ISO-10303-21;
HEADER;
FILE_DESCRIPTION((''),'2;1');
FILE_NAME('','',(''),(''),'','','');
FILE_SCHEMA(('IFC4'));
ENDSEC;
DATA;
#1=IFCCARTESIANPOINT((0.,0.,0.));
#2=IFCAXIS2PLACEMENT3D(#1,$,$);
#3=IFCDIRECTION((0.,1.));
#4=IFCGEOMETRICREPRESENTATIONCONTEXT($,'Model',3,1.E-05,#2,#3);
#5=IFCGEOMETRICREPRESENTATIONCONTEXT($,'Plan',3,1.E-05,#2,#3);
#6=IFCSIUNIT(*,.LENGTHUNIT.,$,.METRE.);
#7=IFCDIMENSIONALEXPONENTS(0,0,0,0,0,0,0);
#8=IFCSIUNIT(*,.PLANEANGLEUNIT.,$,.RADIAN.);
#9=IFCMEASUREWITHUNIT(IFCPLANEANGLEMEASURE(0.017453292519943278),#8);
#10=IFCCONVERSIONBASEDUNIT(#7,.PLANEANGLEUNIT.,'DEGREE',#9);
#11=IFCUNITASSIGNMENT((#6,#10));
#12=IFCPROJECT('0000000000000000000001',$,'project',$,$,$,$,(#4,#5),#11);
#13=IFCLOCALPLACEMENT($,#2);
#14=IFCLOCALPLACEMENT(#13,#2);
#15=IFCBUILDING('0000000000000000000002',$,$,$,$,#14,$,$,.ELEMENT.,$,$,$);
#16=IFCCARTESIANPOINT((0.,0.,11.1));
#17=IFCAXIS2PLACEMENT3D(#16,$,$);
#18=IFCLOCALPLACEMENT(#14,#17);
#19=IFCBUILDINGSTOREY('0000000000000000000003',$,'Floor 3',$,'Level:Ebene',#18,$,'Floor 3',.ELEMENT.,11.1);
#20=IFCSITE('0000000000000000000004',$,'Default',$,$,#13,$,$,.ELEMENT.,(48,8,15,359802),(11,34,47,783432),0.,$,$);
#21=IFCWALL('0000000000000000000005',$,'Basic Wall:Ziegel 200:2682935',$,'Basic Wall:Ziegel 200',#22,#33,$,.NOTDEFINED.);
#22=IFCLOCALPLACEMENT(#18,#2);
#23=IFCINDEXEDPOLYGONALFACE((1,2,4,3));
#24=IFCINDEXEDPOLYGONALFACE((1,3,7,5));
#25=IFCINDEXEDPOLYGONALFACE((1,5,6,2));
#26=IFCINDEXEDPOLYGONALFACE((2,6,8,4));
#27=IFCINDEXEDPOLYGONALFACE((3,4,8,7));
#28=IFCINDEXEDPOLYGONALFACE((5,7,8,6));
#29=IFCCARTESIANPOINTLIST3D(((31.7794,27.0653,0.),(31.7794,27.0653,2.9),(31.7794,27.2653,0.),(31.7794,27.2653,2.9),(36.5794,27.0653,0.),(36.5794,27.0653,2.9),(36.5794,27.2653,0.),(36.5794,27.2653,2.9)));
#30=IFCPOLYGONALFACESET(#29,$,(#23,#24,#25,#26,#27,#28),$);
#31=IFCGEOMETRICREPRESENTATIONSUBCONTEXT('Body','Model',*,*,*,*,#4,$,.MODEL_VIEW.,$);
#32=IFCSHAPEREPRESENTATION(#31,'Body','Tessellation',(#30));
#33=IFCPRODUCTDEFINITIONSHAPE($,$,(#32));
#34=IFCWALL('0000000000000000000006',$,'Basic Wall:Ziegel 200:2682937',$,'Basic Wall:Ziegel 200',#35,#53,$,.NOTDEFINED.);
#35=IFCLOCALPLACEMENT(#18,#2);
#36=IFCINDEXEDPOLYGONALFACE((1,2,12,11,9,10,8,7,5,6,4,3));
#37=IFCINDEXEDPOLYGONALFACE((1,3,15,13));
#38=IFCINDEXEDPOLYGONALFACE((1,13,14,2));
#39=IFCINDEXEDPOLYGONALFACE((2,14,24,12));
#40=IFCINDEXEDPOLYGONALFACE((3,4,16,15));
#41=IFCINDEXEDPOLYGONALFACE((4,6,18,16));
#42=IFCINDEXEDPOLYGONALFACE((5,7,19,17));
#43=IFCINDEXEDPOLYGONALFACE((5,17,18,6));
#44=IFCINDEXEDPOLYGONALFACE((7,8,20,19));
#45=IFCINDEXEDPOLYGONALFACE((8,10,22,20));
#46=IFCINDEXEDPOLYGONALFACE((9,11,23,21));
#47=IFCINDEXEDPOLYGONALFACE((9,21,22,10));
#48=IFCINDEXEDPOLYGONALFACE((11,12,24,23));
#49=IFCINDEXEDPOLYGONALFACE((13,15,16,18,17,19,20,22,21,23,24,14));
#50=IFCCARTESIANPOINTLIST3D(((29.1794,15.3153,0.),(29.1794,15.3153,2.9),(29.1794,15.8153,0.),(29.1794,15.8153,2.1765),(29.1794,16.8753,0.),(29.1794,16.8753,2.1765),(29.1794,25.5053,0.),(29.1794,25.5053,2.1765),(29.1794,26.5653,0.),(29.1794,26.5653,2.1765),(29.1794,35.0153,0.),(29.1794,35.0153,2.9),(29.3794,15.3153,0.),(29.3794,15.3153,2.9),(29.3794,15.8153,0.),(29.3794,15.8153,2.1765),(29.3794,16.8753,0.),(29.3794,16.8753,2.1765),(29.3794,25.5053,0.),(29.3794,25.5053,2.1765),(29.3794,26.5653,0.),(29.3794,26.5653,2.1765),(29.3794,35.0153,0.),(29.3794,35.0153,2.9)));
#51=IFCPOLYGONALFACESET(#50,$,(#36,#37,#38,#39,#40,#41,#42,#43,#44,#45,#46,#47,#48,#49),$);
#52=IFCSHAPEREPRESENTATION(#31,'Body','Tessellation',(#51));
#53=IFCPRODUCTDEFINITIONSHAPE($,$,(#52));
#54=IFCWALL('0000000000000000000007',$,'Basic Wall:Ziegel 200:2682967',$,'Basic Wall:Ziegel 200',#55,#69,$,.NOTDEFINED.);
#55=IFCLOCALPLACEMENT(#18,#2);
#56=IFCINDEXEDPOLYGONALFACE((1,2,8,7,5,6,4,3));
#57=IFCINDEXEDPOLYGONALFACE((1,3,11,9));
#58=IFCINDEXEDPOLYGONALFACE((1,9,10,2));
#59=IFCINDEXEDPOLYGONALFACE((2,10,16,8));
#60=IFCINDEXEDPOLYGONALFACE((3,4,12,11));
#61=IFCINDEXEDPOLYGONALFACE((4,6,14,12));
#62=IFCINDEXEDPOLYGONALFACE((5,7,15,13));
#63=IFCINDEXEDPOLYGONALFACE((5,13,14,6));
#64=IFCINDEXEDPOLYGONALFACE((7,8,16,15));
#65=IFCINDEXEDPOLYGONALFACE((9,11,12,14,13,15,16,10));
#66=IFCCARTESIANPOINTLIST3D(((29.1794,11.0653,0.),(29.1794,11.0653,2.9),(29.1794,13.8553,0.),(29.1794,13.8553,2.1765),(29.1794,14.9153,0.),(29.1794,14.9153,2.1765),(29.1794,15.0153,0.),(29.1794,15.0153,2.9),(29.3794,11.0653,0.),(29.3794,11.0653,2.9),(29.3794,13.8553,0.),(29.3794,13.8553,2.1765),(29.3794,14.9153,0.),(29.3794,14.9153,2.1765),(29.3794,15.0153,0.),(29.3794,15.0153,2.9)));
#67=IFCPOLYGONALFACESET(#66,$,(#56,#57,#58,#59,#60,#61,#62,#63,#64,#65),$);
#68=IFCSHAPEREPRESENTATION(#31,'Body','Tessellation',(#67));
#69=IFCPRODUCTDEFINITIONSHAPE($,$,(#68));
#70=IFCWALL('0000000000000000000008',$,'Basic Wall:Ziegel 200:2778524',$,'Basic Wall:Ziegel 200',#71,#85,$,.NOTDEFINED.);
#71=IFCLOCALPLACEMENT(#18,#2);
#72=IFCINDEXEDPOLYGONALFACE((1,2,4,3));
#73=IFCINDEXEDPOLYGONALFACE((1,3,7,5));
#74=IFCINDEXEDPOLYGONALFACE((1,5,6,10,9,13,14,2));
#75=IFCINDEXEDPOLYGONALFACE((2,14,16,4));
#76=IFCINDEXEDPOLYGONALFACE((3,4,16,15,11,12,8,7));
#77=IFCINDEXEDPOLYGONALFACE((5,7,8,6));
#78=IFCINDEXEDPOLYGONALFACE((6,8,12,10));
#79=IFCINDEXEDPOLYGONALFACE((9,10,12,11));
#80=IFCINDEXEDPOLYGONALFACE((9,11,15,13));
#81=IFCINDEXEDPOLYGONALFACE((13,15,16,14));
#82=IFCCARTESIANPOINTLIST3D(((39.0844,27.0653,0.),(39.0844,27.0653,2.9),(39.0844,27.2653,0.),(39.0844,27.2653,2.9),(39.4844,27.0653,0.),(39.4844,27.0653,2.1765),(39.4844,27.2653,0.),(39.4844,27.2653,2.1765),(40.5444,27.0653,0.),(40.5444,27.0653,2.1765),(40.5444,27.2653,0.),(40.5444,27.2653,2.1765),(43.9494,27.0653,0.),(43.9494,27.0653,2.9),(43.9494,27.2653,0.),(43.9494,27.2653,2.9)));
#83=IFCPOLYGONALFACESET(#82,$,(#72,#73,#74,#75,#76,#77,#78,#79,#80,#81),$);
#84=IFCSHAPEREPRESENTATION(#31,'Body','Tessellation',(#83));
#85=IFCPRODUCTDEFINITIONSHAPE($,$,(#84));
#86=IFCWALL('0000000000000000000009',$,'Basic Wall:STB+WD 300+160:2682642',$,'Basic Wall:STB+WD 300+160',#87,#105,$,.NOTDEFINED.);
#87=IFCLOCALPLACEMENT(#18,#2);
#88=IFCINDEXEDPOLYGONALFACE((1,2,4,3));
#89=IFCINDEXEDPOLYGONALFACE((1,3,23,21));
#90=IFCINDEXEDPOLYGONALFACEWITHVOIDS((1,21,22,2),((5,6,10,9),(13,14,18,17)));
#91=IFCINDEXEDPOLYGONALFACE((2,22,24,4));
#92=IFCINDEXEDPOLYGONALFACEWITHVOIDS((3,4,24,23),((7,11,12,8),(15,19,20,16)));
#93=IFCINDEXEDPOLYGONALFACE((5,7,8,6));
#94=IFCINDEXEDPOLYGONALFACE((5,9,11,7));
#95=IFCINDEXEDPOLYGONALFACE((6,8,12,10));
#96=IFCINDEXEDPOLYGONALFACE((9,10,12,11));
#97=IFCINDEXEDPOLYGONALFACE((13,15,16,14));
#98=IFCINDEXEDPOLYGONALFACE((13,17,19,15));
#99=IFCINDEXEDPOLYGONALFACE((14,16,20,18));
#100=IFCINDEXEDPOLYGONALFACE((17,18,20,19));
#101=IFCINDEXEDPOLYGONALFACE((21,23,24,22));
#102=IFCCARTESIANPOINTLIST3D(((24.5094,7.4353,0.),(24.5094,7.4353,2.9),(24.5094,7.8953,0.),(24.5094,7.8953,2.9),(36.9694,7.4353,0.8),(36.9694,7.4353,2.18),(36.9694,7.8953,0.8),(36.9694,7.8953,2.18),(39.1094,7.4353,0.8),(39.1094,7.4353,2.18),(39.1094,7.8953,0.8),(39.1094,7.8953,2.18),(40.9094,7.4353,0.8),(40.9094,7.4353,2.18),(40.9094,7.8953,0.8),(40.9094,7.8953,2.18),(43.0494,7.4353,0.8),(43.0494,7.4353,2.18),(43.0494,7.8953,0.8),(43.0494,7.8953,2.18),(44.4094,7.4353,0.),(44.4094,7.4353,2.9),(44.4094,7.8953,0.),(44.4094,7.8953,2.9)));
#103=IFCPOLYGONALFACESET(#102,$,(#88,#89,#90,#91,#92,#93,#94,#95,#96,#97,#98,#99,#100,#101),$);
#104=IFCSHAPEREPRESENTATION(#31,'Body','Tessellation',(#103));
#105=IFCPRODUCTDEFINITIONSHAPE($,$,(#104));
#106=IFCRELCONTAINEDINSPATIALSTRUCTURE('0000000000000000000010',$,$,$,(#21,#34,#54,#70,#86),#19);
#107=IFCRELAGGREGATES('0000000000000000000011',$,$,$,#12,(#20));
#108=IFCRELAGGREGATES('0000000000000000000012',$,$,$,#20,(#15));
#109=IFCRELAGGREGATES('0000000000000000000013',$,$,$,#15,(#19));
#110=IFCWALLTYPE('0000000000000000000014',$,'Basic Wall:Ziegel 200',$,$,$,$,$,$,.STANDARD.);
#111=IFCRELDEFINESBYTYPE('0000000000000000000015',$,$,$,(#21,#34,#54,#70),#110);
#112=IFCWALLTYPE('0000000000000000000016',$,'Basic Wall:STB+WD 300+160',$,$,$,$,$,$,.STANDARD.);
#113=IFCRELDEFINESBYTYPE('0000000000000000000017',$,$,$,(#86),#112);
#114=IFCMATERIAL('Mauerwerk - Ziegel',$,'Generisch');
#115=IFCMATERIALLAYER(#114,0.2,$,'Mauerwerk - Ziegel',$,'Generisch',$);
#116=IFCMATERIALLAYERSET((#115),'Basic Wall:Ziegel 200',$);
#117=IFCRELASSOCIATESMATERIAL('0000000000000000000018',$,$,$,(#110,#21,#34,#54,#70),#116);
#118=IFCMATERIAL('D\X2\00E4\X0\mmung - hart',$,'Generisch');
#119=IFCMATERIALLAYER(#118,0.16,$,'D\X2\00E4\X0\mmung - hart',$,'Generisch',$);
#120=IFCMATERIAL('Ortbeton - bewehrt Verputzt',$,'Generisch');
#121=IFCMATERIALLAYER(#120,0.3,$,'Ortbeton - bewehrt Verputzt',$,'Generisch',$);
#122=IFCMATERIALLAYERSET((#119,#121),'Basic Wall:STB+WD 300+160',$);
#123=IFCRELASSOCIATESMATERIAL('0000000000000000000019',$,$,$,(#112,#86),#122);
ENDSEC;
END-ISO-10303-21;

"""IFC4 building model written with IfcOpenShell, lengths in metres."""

from ifc_helpers import new_model, entity, si_unit, converted_unit, direction, frame, frame_2d, origin, place, context, subcontext, project, spatial, rectangle, extrude, material, layer, layer_set, layer_usage, type_object, element, save


model = new_model("IFC4")

# Units and contexts
model_context = context("Model", 3, precision=1e-05, world=origin(), true_north=direction((0.0, 1.0)))
plan_context = context("Plan", 3, precision=1e-05, world=origin(), true_north=direction((0.0, 1.0)))
body_context = subcontext(model_context, "Body", "Model", "MODEL_VIEW")
ifc_project = project(units=[si_unit("LENGTHUNIT", "METRE"), converted_unit("PLANEANGLEUNIT", "DEGREE", entity("IfcPlaneAngleMeasure", 0.017453292519943278), si_unit("PLANEANGLEUNIT", "RADIAN"), dimensions=[0, 0, 0, 0, 0, 0, 0])], contexts=[model_context, plan_context])

# Site, building, storey
site_placement = place(None, origin())
site = spatial("IfcSite", under=ifc_project, at=site_placement, Name="Default", CompositionType="ELEMENT", RefLatitude=(48, 8, 15, 359802), RefLongitude=(11, 34, 47, 783432), RefElevation=0.0)
building_placement = place(site_placement, origin())
building = spatial("IfcBuilding", under=site, at=building_placement, CompositionType="ELEMENT")
storey_placement = place(building_placement, frame((0.0, 0.0, 11.1)))
storey = spatial("IfcBuildingStorey", under=building, at=storey_placement, Name="Floor 3", ObjectType="Level:Ebene", LongName="Floor 3", CompositionType="ELEMENT", Elevation=11.1)

# Shared definitions
ifc_material_1 = material(Name="Ortbeton - bewehrt Verputzt", Category="Generisch")

# Shared definitions
ifc_material_2 = material(Name="Mauerwerk - Ziegel", Category="Generisch")
ifc_layer_1 = layer(ifc_material_2, 0.2, Name="Mauerwerk - Ziegel", Category="Generisch")
ifc_layer_set_1 = layer_set([ifc_layer_1], Name="Basic Wall:Ziegel 200")
ifc_layer_usage_1 = layer_usage(ifc_layer_set_1, "AXIS2", "NEGATIVE", 0.1)
wall_type_1 = type_object("IfcWallType", Name="Basic Wall:Ziegel 200", PredefinedType="STANDARD", material=ifc_layer_set_1)

# Wall
wall_1_placement = place(storey_placement, frame((31.7794, 27.1653, 0.0)))
element("IfcWall", 1, at=wall_1_placement, inside=storey, type_object=wall_type_1, material=ifc_layer_usage_1, Name="Basic Wall:Ziegel 200:2682935", ObjectType="Basic Wall:Ziegel 200", PredefinedType="NOTDEFINED", context=body_context, shape_type="SweptSolid", body=[
    extrude(rectangle(XDim=4.8, YDim=0.2, at=frame_2d((2.4, 0.0), x_axis=(-1.0, 0.0))), origin(), (0.0, 0.0, 1.0), 2.9),
])

# Wall, openings
wall_2_placement = place(storey_placement, frame((29.2794, 15.3153, 0.0), z_axis=(0.0, 0.0, 1.0), x_axis=(0.0, 1.0, 0.0)))
wall_2 = element("IfcWall", 2, at=wall_2_placement, inside=storey, type_object=wall_type_1, material=ifc_layer_usage_1, Name="Basic Wall:Ziegel 200:2682937", ObjectType="Basic Wall:Ziegel 200", PredefinedType="NOTDEFINED", context=body_context, shape_type="SweptSolid", body=[
    extrude(rectangle(XDim=19.7, YDim=0.2, at=frame_2d((9.85, 0.0), x_axis=(1.0, 0.0))), origin(), (0.0, 0.0, 1.0), 2.9),
])
opening_1_placement = place(wall_2_placement, frame((11.25, 0.1, 0.0)))
element("IfcOpeningElement", 3, at=opening_1_placement, cuts=wall_2, PredefinedType="OPENING", context=body_context, shape_type="SweptSolid", body=[
    extrude(rectangle(XDim=2.1765, YDim=1.06, at=frame_2d((1.0882, 0.53), x_axis=(1.0, 0.0))), frame((0.0, 0.0, 0.0), z_axis=(0.0, -1.0, 0.0), x_axis=(0.0, 0.0, 1.0)), (0.0, 0.0, 1.0), 0.2),
])
opening_2_placement = place(wall_2_placement, frame((1.56, 0.1, 0.0)))
element("IfcOpeningElement", 4, at=opening_2_placement, cuts=wall_2, PredefinedType="OPENING", context=body_context, shape_type="SweptSolid", body=[
    extrude(rectangle(XDim=2.1765, YDim=1.06, at=frame_2d((1.0882, 0.53), x_axis=(1.0, 0.0))), frame((0.0, 0.0, 0.0), z_axis=(0.0, -1.0, 0.0), x_axis=(0.0, 0.0, 1.0)), (0.0, 0.0, 1.0), 0.2),
])

# Walls, openings
wall_3_placement = place(storey_placement, frame((29.2794, 15.0153, 0.0), z_axis=(0.0, 0.0, 1.0), x_axis=(0.0, -1.0, 0.0)))
wall_3 = element("IfcWall", 5, at=wall_3_placement, inside=storey, type_object=wall_type_1, material=ifc_layer_usage_1, Name="Basic Wall:Ziegel 200:2682967", ObjectType="Basic Wall:Ziegel 200", PredefinedType="NOTDEFINED", context=body_context, shape_type="SweptSolid", body=[
    extrude(rectangle(XDim=3.95, YDim=0.2, at=frame_2d((1.975, 0.0), x_axis=(-1.0, 0.0))), origin(), (0.0, 0.0, 1.0), 2.9),
])
opening_3_placement = place(wall_3_placement, frame((0.1, -0.1, 0.0)))
element("IfcOpeningElement", 6, at=opening_3_placement, cuts=wall_3, PredefinedType="OPENING", context=body_context, shape_type="SweptSolid", body=[
    extrude(rectangle(XDim=2.1765, YDim=1.06, at=frame_2d((1.0882, 0.53), x_axis=(1.0, 0.0))), frame((0.0, 0.0, 0.0), z_axis=(0.0, 1.0, 0.0), x_axis=(0.0, 0.0, 1.0)), (0.0, 0.0, 1.0), 0.2),
])
wall_4_placement = place(storey_placement, frame((39.0844, 27.1653, 0.0)))
wall_4 = element("IfcWall", 7, at=wall_4_placement, inside=storey, type_object=wall_type_1, material=ifc_layer_usage_1, Name="Basic Wall:Ziegel 200:2778524", ObjectType="Basic Wall:Ziegel 200", PredefinedType="NOTDEFINED", context=body_context, shape_type="SweptSolid", body=[
    extrude(rectangle(XDim=4.865, YDim=0.2, at=frame_2d((2.4325, 0.0), x_axis=(1.0, 0.0))), origin(), (0.0, 0.0, 1.0), 2.9),
])
opening_4_placement = place(wall_4_placement, frame((1.46, 0.1, 0.0)))
element("IfcOpeningElement", 8, at=opening_4_placement, cuts=wall_4, PredefinedType="OPENING", context=body_context, shape_type="SweptSolid", body=[
    extrude(rectangle(XDim=2.1765, YDim=1.06, at=frame_2d((1.0882, 0.53), x_axis=(1.0, 0.0))), frame((0.0, 0.0, 0.0), z_axis=(0.0, -1.0, 0.0), x_axis=(0.0, 0.0, 1.0)), (0.0, 0.0, 1.0), 0.2),
])

# Wall, openings
ifc_material_3 = material(Name="Dämmung - hart", Category="Generisch")
ifc_layer_2 = layer(ifc_material_3, 0.16, Name="Dämmung - hart", Category="Generisch")
ifc_layer_3 = layer(ifc_material_1, 0.3, Name="Ortbeton - bewehrt Verputzt", Category="Generisch")
ifc_layer_set_2 = layer_set([ifc_layer_2, ifc_layer_3], Name="Basic Wall:STB+WD 300+160")
ifc_layer_usage_2 = layer_usage(ifc_layer_set_2, "AXIS2", "POSITIVE", -0.23)
wall_type_2 = type_object("IfcWallType", Name="Basic Wall:STB+WD 300+160", PredefinedType="STANDARD", material=ifc_layer_set_2)
wall_5_placement = place(storey_placement, frame((24.5094, 7.6653, 0.0)))
wall_5 = element("IfcWall", 9, at=wall_5_placement, inside=storey, type_object=wall_type_2, material=ifc_layer_usage_2, Name="Basic Wall:STB+WD 300+160:2682642", ObjectType="Basic Wall:STB+WD 300+160", PredefinedType="NOTDEFINED", context=body_context, shape_type="SweptSolid", body=[
    extrude(rectangle(XDim=19.9, YDim=0.46, at=frame_2d((9.95, 0.0), x_axis=(-1.0, 0.0))), origin(), (0.0, 0.0, 1.0), 2.9),
])
opening_5_placement = place(wall_5_placement, frame((-24.5094, -7.6653, 0.8)))
element("IfcOpeningElement", 10, at=opening_5_placement, cuts=wall_5, PredefinedType="OPENING", context=body_context, shape_type="SweptSolid", body=[
    extrude(rectangle(XDim=1.38, YDim=2.14, at=frame_2d((0.0, 0.0), x_axis=(0.0, 1.0))), frame((41.9794, 6.3713, 0.69), z_axis=(0.0, 1.0, 0.0), x_axis=(-1.0, 0.0, 0.0)), (0.0, 0.0, 1.0), 3.048),
])
opening_6_placement = place(wall_5_placement, frame((-24.5094, -7.6653, 0.8)))
element("IfcOpeningElement", 11, at=opening_6_placement, cuts=wall_5, PredefinedType="OPENING", context=body_context, shape_type="SweptSolid", body=[
    extrude(rectangle(XDim=1.38, YDim=2.14, at=frame_2d((0.0, 0.0), x_axis=(0.0, 1.0))), frame((38.0394, 6.3713, 0.69), z_axis=(0.0, 1.0, 0.0), x_axis=(-1.0, 0.0, 0.0)), (0.0, 0.0, 1.0), 3.048),
])

save(model, "model.ifc")
